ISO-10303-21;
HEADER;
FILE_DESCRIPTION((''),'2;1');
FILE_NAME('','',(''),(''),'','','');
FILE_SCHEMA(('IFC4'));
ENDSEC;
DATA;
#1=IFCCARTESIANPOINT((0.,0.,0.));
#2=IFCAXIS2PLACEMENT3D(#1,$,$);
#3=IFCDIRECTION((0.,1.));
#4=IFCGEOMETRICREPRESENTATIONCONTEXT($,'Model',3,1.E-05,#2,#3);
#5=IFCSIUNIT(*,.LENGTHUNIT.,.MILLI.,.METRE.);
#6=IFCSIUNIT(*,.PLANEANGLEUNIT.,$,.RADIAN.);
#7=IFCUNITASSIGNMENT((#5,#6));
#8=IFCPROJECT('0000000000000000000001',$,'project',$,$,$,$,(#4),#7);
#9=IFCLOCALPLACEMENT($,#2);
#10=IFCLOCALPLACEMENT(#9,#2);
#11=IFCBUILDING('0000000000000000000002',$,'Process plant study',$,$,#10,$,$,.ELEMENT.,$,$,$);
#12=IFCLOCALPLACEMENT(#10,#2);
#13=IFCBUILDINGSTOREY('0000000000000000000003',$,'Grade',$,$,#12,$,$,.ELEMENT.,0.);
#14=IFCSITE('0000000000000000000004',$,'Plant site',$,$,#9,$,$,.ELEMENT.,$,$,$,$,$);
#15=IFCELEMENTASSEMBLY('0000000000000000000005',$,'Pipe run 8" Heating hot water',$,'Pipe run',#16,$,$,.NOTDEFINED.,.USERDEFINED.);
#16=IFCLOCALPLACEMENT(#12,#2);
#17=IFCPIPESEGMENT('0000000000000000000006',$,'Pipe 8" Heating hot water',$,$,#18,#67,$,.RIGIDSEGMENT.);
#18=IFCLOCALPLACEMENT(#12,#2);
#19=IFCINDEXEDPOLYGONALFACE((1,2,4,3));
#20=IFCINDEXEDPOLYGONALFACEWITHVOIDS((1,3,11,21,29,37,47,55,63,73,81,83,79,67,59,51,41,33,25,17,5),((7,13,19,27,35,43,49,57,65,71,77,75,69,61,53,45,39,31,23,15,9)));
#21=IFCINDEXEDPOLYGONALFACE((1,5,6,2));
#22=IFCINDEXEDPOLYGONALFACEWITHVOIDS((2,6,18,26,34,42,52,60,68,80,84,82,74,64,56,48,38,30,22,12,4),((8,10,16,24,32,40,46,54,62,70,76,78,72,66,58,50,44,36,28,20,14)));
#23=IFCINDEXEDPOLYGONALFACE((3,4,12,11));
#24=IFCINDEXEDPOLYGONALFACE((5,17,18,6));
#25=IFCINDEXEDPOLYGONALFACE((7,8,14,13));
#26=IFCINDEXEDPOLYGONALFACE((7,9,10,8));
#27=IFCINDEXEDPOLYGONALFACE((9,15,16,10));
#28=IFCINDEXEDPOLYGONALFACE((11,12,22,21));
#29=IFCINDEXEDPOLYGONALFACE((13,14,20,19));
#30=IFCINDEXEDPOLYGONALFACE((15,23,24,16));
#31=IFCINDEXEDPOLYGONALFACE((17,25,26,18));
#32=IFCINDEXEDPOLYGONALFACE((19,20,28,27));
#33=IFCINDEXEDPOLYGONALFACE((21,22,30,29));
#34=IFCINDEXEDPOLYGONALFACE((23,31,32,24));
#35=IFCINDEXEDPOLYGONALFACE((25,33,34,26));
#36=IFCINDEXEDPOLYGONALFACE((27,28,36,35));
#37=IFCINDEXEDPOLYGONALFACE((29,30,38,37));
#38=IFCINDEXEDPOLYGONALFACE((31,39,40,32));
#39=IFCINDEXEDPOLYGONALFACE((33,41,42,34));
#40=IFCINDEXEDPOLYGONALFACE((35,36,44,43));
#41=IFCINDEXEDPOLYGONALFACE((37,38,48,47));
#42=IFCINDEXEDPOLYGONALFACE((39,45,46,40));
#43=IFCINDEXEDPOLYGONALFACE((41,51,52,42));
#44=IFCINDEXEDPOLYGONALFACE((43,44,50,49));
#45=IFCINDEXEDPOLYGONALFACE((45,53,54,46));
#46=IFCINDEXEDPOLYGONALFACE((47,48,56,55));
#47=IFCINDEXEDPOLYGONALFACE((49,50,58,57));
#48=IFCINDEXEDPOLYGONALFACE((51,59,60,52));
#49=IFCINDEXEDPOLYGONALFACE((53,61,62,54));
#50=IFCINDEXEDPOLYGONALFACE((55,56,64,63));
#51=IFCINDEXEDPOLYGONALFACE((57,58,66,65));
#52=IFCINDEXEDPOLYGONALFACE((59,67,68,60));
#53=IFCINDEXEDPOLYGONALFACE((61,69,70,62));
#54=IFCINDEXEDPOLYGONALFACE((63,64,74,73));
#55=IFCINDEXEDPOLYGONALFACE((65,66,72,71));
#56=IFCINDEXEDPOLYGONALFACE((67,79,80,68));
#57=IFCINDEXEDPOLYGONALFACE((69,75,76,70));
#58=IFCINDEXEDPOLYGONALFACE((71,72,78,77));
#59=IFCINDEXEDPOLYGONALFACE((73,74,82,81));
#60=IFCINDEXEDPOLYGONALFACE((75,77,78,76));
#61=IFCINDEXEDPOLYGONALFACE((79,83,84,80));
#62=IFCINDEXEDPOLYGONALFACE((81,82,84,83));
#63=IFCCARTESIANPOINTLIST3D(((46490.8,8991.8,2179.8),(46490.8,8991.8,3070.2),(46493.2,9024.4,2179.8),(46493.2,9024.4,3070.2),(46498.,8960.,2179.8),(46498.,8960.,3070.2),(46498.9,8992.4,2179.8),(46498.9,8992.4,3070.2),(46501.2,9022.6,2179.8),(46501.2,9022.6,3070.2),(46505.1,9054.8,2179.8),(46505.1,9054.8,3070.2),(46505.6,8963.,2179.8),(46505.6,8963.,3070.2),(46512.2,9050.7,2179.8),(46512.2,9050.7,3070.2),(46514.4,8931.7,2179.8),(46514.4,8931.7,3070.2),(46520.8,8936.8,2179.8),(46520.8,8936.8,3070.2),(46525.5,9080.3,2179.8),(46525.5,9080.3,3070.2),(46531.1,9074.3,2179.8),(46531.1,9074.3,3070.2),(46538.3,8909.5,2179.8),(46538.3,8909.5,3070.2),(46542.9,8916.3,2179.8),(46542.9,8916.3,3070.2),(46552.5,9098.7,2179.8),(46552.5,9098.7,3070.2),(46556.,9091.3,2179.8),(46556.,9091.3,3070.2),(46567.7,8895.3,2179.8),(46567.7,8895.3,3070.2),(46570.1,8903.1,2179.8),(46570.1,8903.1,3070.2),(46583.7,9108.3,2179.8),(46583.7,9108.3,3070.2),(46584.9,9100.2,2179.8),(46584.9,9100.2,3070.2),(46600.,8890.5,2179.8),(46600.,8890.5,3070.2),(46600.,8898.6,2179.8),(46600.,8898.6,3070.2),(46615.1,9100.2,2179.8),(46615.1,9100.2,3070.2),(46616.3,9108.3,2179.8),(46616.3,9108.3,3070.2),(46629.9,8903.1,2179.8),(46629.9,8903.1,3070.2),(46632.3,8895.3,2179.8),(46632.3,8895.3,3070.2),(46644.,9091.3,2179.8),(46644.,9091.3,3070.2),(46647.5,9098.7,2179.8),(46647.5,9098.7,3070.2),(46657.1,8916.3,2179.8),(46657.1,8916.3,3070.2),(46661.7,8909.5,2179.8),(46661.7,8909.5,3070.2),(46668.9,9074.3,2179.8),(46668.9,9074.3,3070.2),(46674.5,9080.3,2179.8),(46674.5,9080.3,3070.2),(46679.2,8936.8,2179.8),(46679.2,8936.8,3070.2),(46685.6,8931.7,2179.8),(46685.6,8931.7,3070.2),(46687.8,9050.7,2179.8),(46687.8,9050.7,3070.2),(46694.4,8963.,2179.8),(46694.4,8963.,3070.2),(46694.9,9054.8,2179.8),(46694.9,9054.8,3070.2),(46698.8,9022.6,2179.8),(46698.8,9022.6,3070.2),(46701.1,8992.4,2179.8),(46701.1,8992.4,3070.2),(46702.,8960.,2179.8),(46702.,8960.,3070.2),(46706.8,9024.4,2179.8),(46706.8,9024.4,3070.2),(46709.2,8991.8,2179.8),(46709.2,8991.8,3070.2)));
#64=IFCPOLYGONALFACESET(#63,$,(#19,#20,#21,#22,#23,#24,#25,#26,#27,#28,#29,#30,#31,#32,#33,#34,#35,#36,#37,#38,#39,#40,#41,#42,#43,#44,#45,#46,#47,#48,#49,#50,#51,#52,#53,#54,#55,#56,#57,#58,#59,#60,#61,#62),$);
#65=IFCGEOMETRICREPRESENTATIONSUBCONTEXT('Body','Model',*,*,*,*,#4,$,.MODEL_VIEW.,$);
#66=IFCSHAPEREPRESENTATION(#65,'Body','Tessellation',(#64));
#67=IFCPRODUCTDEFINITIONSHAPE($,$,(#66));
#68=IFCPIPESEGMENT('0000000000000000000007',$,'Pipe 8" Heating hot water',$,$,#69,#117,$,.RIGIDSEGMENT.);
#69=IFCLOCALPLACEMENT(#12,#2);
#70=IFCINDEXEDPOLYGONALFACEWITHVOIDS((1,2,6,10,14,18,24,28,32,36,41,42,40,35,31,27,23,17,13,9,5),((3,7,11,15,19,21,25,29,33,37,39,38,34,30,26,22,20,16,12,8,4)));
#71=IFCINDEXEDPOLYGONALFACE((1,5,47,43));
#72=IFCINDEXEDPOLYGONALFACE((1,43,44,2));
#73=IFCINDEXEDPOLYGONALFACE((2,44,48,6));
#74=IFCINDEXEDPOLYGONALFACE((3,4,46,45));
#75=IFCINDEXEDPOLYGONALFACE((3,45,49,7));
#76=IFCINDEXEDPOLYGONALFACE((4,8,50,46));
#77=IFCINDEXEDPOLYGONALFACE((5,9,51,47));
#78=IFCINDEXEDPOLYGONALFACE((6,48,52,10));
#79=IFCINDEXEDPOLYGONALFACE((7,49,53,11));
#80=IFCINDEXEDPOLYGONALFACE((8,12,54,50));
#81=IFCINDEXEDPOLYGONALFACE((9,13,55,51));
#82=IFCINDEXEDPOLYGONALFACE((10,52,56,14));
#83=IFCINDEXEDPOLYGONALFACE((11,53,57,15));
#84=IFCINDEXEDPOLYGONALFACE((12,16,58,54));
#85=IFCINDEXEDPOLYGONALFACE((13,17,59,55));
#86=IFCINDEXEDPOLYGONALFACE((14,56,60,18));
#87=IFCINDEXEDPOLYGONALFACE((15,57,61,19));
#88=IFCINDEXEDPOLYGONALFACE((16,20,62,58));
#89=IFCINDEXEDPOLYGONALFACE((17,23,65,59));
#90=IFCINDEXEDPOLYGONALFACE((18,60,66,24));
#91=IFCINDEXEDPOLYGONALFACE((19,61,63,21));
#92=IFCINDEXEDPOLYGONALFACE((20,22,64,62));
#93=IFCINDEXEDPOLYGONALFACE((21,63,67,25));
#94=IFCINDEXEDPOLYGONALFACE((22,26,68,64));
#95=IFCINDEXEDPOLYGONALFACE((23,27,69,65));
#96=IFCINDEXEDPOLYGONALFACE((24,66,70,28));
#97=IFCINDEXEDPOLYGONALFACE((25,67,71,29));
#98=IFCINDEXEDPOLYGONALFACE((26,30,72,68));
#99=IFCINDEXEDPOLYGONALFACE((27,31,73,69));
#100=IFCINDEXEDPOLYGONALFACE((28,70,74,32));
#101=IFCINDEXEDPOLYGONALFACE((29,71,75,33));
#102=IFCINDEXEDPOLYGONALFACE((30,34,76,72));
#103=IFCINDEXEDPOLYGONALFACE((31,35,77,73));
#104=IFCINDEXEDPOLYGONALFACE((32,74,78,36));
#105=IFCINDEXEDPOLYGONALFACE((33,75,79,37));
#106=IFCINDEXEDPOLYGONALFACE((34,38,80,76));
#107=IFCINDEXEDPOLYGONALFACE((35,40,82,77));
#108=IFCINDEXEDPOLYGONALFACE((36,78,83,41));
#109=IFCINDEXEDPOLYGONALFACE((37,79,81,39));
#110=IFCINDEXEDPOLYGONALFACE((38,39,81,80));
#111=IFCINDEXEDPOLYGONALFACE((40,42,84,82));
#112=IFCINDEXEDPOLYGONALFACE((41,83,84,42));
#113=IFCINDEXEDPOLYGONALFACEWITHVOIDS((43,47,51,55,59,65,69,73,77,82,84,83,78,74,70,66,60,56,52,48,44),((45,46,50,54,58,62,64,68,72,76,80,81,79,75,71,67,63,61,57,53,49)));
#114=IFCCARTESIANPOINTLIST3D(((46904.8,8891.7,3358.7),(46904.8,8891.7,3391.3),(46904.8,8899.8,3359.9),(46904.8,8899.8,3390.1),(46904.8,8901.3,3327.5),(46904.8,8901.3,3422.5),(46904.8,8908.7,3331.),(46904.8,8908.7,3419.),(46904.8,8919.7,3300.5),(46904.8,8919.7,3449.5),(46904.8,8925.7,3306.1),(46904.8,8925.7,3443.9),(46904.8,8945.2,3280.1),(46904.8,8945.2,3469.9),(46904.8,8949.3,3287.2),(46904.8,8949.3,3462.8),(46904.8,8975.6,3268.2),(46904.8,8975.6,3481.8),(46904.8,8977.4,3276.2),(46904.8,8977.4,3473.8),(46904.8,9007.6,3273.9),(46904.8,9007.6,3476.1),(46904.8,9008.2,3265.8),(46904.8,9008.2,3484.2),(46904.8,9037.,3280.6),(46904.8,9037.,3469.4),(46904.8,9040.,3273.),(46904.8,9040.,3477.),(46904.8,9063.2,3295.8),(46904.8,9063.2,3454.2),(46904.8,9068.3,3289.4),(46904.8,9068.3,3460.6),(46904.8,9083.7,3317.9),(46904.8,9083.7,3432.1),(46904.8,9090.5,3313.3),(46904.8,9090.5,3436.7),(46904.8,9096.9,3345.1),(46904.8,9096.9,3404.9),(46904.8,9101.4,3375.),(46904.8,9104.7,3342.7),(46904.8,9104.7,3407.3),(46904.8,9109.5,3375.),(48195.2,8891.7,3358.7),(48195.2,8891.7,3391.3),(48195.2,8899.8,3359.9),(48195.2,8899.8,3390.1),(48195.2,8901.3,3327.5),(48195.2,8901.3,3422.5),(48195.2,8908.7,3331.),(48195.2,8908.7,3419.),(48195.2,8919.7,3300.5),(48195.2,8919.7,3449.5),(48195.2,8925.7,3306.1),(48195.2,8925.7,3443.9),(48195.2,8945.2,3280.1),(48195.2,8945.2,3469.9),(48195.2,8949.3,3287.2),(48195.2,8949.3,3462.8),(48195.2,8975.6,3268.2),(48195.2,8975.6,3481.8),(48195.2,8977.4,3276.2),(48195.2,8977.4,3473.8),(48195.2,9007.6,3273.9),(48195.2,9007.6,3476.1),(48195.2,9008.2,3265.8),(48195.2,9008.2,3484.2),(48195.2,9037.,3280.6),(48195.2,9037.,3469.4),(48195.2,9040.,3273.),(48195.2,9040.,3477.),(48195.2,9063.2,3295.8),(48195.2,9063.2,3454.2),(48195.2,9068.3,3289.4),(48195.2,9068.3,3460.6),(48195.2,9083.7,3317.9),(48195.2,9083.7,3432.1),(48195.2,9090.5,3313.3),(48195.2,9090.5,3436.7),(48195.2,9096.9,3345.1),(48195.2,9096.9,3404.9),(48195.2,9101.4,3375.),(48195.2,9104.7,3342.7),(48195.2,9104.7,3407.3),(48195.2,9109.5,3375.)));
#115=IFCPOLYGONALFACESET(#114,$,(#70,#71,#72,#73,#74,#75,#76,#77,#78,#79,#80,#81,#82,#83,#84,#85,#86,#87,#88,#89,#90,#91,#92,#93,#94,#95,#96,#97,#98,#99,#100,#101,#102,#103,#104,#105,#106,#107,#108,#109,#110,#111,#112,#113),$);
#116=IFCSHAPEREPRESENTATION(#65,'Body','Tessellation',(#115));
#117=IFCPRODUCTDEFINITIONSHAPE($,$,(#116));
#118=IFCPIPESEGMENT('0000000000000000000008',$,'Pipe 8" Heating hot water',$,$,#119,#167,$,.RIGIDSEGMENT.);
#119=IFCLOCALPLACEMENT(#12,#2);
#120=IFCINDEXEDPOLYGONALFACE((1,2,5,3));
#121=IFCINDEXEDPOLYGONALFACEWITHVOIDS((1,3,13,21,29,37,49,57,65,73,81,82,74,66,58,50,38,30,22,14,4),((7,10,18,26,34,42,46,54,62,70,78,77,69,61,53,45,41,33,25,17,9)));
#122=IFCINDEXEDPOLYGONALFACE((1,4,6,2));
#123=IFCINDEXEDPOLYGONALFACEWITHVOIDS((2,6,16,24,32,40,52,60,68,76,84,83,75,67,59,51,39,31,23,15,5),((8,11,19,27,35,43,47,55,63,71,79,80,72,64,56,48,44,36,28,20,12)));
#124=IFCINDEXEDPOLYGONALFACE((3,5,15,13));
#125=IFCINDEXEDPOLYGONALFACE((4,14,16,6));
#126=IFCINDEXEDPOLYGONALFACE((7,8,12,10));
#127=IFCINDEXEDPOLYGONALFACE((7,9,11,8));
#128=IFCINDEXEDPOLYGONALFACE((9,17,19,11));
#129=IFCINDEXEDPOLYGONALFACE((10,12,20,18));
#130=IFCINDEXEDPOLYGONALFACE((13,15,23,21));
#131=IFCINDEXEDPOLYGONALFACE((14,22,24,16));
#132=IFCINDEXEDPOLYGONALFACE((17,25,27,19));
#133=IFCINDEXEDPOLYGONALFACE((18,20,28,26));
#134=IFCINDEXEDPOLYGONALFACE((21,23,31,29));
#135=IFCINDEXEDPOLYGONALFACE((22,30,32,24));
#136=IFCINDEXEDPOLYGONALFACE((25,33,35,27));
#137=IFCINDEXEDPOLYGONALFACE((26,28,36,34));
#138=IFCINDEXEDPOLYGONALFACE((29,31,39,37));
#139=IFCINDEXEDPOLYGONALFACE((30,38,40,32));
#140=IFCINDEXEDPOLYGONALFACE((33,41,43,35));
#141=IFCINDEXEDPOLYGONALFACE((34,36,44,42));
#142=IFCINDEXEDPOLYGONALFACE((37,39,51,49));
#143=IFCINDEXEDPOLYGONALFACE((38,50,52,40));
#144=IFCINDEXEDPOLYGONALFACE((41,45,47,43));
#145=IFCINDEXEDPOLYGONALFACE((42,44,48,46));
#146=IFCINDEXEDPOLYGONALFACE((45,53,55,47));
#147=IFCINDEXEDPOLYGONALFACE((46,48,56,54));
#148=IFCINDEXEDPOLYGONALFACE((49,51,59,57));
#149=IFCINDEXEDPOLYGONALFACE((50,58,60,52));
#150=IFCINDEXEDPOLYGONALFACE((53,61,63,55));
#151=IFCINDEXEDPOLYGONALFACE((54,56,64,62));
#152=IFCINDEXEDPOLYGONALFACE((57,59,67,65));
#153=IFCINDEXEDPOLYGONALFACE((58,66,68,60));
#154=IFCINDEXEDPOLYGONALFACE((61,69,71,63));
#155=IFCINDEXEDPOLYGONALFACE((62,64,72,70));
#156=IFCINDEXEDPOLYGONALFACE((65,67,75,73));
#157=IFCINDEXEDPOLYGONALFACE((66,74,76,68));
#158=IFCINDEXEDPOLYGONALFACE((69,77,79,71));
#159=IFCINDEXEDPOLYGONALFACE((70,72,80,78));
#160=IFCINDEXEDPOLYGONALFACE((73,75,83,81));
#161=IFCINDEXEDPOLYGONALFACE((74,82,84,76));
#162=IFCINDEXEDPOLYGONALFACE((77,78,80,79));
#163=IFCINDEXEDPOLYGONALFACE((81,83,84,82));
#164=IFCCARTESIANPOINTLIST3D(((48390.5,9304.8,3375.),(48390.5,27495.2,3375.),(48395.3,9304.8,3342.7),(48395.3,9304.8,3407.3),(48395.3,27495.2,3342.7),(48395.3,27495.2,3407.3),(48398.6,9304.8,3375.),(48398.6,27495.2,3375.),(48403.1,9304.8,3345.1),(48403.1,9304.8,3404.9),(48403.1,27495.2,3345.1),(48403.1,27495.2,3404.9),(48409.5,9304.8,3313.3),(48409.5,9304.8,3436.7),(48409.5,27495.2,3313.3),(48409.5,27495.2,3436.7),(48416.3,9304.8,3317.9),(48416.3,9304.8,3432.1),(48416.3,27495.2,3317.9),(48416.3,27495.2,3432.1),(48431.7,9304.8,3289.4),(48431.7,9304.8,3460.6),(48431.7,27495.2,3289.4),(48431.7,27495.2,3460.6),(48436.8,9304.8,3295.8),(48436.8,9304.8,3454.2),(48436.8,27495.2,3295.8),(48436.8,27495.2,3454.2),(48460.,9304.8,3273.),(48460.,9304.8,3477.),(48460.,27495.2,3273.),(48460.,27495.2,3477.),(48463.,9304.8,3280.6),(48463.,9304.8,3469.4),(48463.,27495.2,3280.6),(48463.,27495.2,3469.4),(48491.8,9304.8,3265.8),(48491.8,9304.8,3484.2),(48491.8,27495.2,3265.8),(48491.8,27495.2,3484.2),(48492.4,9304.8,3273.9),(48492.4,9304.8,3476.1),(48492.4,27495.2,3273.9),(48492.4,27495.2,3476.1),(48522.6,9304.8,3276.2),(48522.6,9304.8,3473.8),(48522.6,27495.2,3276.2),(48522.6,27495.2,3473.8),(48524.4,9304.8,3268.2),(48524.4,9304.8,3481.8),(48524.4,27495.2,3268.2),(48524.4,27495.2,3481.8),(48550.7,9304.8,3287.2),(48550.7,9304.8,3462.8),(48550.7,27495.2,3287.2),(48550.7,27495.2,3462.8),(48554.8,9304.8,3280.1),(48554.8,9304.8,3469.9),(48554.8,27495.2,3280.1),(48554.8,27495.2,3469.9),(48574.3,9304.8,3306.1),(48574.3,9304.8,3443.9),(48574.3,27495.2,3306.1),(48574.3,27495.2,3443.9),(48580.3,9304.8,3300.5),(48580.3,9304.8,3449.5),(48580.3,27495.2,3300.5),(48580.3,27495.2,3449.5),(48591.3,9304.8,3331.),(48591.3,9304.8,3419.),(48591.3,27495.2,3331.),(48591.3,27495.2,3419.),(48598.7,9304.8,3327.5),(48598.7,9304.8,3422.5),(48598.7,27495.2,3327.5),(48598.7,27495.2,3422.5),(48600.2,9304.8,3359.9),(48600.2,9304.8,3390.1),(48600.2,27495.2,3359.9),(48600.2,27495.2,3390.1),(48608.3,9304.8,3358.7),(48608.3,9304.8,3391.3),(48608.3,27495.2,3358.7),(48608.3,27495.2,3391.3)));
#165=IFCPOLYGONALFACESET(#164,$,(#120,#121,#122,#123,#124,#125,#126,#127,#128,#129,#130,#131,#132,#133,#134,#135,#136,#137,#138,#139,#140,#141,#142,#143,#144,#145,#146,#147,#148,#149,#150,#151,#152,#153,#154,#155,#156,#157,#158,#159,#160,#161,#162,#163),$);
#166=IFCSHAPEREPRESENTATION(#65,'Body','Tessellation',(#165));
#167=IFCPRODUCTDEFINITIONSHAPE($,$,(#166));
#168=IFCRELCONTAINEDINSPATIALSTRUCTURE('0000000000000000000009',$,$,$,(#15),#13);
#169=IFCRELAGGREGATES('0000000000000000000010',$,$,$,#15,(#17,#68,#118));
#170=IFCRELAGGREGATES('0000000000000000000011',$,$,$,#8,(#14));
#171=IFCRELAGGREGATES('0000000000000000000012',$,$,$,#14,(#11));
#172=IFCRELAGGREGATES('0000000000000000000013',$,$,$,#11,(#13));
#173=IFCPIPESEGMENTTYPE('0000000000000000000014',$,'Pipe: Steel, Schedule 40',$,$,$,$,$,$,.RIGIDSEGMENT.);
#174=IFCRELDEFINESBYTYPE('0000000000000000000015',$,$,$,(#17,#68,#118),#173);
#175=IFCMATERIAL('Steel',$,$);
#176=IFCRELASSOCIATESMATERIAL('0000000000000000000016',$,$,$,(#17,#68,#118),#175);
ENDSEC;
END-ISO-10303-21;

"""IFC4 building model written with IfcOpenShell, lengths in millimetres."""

from ifc_helpers import new_model, si_unit, direction, frame, origin, origin_with_axes, origin_2d, place, context, subcontext, project, spatial, hollow_circle, extrude, material, type_object, element, aggregate, save


model = new_model("IFC4")

# Units and contexts
model_context = context("Model", 3, precision=1e-05, world=origin(), true_north=direction((0.0, 1.0)))
body_context = subcontext(model_context, "Body", "Model", "MODEL_VIEW")
ifc_project = project(units=[si_unit("LENGTHUNIT", "METRE", prefix="MILLI"), si_unit("PLANEANGLEUNIT", "RADIAN")], contexts=[model_context])

# Site, building, storey
site_placement = place(None, origin())
site = spatial("IfcSite", under=ifc_project, at=site_placement, Name="Plant site", CompositionType="ELEMENT")
building_placement = place(site_placement, origin())
building = spatial("IfcBuilding", under=site, at=building_placement, Name="Process plant study", CompositionType="ELEMENT")
storey_placement = place(building_placement, origin())
storey = spatial("IfcBuildingStorey", under=building, at=storey_placement, Name="Grade", CompositionType="ELEMENT", Elevation=0.0)

# Element assembly, pipe segments
ifc_material = material(Name="Steel")
pipe_segment_type = type_object("IfcPipeSegmentType", Name="Pipe: Steel, Schedule 40", PredefinedType="RIGIDSEGMENT")
assembly_1_placement = place(storey_placement, origin_with_axes())
assembly_1 = element("IfcElementAssembly", 1, at=assembly_1_placement, inside=storey, Name="Pipe run 8\" Heating hot water", ObjectType="Pipe run", AssemblyPlace="NOTDEFINED", PredefinedType="USERDEFINED")
pipe_segment_1_placement = place(storey_placement, origin_with_axes())
pipe_segment_1 = element("IfcPipeSegment", 2, at=pipe_segment_1_placement, type_object=pipe_segment_type, material=ifc_material, Name="Pipe 8\" Heating hot water", PredefinedType="RIGIDSEGMENT", context=body_context, shape_type="SweptSolid", body=[
    extrude(hollow_circle(Radius=109.5, WallThickness=8.2, at=origin_2d()), frame((46600.0, 9000.0, 2179.8), z_axis=(0.0, 0.0, 1.0), x_axis=(0.0, -1.0, 0.0)), (0.0, 0.0, 1.0), 890.4),
])
pipe_segment_2_placement = place(storey_placement, origin_with_axes())
pipe_segment_2 = element("IfcPipeSegment", 3, at=pipe_segment_2_placement, type_object=pipe_segment_type, material=ifc_material, Name="Pipe 8\" Heating hot water", PredefinedType="RIGIDSEGMENT", context=body_context, shape_type="SweptSolid", body=[
    extrude(hollow_circle(Radius=109.5, WallThickness=8.2, at=origin_2d()), frame((46904.8, 9000.0, 3375.0), z_axis=(1.0, 0.0, 0.0), x_axis=(0.0, 1.0, 0.0)), (0.0, 0.0, 1.0), 1290.4),
])
pipe_segment_3_placement = place(storey_placement, origin_with_axes())
pipe_segment_3 = element("IfcPipeSegment", 4, at=pipe_segment_3_placement, type_object=pipe_segment_type, material=ifc_material, Name="Pipe 8\" Heating hot water", PredefinedType="RIGIDSEGMENT", context=body_context, shape_type="SweptSolid", body=[
    extrude(hollow_circle(Radius=109.5, WallThickness=8.2, at=origin_2d()), frame((48500.0, 9304.8, 3375.0), z_axis=(0.0, 1.0, 0.0), x_axis=(-1.0, 0.0, 0.0)), (0.0, 0.0, 1.0), 18190.4),
])

aggregate(assembly_1, [pipe_segment_1, pipe_segment_2, pipe_segment_3])

save(model, "model.ifc")
